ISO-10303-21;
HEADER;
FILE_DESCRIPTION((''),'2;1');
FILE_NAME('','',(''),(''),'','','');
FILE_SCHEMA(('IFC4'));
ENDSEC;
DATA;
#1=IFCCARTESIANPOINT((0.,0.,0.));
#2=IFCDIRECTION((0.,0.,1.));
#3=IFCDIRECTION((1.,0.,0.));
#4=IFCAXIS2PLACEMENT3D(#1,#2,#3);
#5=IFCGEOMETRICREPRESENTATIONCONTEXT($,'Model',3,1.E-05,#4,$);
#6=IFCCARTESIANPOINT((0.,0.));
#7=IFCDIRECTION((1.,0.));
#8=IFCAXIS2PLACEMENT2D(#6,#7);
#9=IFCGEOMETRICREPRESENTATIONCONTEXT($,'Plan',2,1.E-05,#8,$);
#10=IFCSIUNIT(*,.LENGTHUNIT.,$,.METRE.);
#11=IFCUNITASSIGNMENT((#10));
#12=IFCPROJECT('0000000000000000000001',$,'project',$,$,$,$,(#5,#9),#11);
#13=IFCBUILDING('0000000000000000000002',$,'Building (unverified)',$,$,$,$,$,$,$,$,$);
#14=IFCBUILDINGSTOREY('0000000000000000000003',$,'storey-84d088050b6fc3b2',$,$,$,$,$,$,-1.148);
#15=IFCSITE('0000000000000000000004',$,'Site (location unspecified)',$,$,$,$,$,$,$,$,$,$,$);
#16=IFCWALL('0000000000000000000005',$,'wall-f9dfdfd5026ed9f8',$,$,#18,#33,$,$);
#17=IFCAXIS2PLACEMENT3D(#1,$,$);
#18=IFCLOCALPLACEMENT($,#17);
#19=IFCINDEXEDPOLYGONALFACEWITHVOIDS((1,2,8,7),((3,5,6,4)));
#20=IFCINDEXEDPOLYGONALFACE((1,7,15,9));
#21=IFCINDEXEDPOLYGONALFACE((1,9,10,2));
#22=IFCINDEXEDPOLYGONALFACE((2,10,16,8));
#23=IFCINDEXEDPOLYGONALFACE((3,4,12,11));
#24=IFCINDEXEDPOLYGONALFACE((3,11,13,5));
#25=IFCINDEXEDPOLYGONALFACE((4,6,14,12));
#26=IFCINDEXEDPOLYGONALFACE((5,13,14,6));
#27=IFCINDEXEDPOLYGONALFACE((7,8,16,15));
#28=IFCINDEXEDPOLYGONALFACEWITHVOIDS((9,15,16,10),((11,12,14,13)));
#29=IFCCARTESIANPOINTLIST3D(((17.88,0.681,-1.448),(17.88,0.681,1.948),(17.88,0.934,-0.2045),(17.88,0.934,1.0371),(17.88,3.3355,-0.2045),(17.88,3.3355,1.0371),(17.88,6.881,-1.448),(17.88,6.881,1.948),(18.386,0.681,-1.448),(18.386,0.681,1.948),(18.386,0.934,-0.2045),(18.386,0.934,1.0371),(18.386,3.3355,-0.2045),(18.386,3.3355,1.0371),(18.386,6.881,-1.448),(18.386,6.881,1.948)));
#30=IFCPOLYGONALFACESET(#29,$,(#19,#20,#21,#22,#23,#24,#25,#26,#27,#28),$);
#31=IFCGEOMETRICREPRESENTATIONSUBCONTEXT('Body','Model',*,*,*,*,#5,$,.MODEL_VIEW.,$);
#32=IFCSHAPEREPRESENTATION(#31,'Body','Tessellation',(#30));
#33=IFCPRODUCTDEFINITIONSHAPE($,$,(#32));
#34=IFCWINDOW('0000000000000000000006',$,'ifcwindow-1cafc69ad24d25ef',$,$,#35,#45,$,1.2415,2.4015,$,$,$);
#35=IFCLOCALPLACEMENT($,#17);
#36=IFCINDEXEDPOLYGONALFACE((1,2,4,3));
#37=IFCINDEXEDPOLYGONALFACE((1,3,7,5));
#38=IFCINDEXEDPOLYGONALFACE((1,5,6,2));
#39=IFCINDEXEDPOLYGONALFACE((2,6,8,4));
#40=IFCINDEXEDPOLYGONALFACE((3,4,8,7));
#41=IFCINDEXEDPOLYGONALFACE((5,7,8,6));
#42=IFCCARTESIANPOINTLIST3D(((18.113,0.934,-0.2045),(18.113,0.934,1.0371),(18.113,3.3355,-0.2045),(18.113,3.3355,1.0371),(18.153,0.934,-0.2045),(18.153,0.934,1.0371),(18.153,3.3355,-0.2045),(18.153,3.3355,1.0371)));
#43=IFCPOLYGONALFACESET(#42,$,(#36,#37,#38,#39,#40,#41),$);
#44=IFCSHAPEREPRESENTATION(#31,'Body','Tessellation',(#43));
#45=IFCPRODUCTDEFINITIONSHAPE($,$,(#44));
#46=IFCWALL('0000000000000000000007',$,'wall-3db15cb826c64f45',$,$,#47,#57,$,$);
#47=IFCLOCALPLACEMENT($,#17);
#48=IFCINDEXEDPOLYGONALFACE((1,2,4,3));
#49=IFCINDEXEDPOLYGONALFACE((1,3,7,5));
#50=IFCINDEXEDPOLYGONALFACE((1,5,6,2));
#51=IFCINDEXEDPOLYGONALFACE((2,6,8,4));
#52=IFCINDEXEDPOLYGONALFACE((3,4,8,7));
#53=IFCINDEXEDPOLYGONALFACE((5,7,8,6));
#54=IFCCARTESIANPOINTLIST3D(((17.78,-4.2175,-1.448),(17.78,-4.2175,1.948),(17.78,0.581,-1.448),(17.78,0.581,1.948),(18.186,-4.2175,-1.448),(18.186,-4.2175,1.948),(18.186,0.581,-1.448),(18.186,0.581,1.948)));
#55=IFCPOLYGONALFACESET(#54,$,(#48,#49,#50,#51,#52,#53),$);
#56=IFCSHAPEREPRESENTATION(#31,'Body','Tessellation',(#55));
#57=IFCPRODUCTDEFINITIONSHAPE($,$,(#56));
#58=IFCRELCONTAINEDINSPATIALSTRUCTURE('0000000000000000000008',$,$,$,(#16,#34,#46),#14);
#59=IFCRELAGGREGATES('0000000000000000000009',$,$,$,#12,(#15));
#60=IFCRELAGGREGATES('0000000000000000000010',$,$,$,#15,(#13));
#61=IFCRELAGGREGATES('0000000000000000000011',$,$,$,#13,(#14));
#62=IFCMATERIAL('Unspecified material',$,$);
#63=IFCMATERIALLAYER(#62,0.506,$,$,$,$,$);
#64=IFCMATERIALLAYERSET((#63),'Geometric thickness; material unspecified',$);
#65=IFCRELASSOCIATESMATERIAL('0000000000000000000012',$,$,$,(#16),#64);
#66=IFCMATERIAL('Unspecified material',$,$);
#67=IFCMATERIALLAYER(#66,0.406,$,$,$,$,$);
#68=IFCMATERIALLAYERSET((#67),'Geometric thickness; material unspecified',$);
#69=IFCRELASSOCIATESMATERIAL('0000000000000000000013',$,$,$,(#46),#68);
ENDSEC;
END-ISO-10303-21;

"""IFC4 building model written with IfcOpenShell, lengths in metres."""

from ifc_helpers import new_model, si_unit, frame, origin_with_axes, origin_2d_with_axis, place, context, subcontext, project, spatial, indexed_curve, outline, extrude, material, layer, layer_set, layer_usage, element, fill, save


model = new_model("IFC4")

# Units and contexts
model_context = context("Model", 3, precision=1e-05, world=origin_with_axes())
plan_context = context("Plan", 2, precision=1e-05, world=origin_2d_with_axis())
body_context = subcontext(model_context, "Body", "Model", "MODEL_VIEW")
ifc_project = project(units=[si_unit("LENGTHUNIT", "METRE")], contexts=[model_context, plan_context])

# Site, building, storey
site = spatial("IfcSite", under=ifc_project, Name="Site (location unspecified)")
building = spatial("IfcBuilding", under=site, Name="Building (unverified)")
storey = spatial("IfcBuildingStorey", under=building, Name="storey-84d088050b6fc3b2", Elevation=-1.148)

# Wall, opening, window
ifc_material_1 = material(Name="Unspecified material")
ifc_layer_1 = layer(ifc_material_1, 0.506)
ifc_layer_set_1 = layer_set([ifc_layer_1], Name="Geometric thickness; material unspecified")
ifc_layer_usage_1 = layer_usage(ifc_layer_set_1, "AXIS2", "POSITIVE", -0.253)
wall_1_placement = place(None, frame((18.133, 0.681, -1.448), z_axis=(0.0, 0.0, 1.0), x_axis=(0.0, 1.0, 0.0)))
wall_1 = element("IfcWall", 1, at=wall_1_placement, inside=storey, material=ifc_layer_usage_1, Name="wall-f9dfdfd5026ed9f8", context=body_context, shape_type="SweptSolid", body=[
    extrude(outline(indexed_curve([(0.0, 0.0), (0.0, 0.506), (6.2, 0.506), (6.2, 0.0), (0.0, 0.0)], self_intersect=False)), frame((0.0, -0.253, 0.0), z_axis=(0.0, 0.0, 1.0), x_axis=(1.0, 0.0, 0.0)), (0.0, 0.0, 1.0), 3.396),
])
opening_1_placement = place(wall_1_placement, frame((0.253, -0.263, 1.2435), z_axis=(0.0, 0.0, 1.0), x_axis=(1.0, 0.0, 0.0)))
opening_1 = element("IfcOpeningElement", 2, at=opening_1_placement, cuts=wall_1, context=body_context, shape_type="SweptSolid", body=[
    extrude(outline(indexed_curve([(0.0, 0.0), (0.0, 0.526), (2.4015, 0.526), (2.4015, 0.0), (0.0, 0.0)], self_intersect=False)), origin_with_axes(), (0.0, 0.0, 1.0), 1.2415),
])
window_1_placement = place(None, frame((18.153, 0.934, -0.2045), z_axis=(0.0, 0.0, 1.0), x_axis=(0.0, 1.0, 0.0)))
window_1 = element("IfcWindow", 3, at=window_1_placement, inside=storey, Name="ifcwindow-1cafc69ad24d25ef", OverallHeight=1.2415, OverallWidth=2.4015, context=body_context, shape_type="SweptSolid", body=[
    extrude(outline(indexed_curve([(0.0, 0.0), (0.0, 0.04), (2.4015, 0.04), (2.4015, 0.0), (0.0, 0.0)], self_intersect=False)), origin_with_axes(), (0.0, 0.0, 1.0), 1.2415),
])
fill(opening_1, window_1)

# Wall
ifc_material_2 = material(Name="Unspecified material")
ifc_layer_2 = layer(ifc_material_2, 0.406)
ifc_layer_set_2 = layer_set([ifc_layer_2], Name="Geometric thickness; material unspecified")
ifc_layer_usage_2 = layer_usage(ifc_layer_set_2, "AXIS2", "POSITIVE", -0.203)
wall_2_placement = place(None, frame((17.983, -4.2175, -1.448), z_axis=(0.0, 0.0, 1.0), x_axis=(0.0, 1.0, 0.0)))
element("IfcWall", 4, at=wall_2_placement, inside=storey, material=ifc_layer_usage_2, Name="wall-3db15cb826c64f45", context=body_context, shape_type="SweptSolid", body=[
    extrude(outline(indexed_curve([(0.0, 0.0), (0.0, 0.406), (4.7985, 0.406), (4.7985, 0.0), (0.0, 0.0)], self_intersect=False)), frame((0.0, -0.203, 0.0), z_axis=(0.0, 0.0, 1.0), x_axis=(1.0, 0.0, 0.0)), (0.0, 0.0, 1.0), 3.396),
])

save(model, "model.ifc")
